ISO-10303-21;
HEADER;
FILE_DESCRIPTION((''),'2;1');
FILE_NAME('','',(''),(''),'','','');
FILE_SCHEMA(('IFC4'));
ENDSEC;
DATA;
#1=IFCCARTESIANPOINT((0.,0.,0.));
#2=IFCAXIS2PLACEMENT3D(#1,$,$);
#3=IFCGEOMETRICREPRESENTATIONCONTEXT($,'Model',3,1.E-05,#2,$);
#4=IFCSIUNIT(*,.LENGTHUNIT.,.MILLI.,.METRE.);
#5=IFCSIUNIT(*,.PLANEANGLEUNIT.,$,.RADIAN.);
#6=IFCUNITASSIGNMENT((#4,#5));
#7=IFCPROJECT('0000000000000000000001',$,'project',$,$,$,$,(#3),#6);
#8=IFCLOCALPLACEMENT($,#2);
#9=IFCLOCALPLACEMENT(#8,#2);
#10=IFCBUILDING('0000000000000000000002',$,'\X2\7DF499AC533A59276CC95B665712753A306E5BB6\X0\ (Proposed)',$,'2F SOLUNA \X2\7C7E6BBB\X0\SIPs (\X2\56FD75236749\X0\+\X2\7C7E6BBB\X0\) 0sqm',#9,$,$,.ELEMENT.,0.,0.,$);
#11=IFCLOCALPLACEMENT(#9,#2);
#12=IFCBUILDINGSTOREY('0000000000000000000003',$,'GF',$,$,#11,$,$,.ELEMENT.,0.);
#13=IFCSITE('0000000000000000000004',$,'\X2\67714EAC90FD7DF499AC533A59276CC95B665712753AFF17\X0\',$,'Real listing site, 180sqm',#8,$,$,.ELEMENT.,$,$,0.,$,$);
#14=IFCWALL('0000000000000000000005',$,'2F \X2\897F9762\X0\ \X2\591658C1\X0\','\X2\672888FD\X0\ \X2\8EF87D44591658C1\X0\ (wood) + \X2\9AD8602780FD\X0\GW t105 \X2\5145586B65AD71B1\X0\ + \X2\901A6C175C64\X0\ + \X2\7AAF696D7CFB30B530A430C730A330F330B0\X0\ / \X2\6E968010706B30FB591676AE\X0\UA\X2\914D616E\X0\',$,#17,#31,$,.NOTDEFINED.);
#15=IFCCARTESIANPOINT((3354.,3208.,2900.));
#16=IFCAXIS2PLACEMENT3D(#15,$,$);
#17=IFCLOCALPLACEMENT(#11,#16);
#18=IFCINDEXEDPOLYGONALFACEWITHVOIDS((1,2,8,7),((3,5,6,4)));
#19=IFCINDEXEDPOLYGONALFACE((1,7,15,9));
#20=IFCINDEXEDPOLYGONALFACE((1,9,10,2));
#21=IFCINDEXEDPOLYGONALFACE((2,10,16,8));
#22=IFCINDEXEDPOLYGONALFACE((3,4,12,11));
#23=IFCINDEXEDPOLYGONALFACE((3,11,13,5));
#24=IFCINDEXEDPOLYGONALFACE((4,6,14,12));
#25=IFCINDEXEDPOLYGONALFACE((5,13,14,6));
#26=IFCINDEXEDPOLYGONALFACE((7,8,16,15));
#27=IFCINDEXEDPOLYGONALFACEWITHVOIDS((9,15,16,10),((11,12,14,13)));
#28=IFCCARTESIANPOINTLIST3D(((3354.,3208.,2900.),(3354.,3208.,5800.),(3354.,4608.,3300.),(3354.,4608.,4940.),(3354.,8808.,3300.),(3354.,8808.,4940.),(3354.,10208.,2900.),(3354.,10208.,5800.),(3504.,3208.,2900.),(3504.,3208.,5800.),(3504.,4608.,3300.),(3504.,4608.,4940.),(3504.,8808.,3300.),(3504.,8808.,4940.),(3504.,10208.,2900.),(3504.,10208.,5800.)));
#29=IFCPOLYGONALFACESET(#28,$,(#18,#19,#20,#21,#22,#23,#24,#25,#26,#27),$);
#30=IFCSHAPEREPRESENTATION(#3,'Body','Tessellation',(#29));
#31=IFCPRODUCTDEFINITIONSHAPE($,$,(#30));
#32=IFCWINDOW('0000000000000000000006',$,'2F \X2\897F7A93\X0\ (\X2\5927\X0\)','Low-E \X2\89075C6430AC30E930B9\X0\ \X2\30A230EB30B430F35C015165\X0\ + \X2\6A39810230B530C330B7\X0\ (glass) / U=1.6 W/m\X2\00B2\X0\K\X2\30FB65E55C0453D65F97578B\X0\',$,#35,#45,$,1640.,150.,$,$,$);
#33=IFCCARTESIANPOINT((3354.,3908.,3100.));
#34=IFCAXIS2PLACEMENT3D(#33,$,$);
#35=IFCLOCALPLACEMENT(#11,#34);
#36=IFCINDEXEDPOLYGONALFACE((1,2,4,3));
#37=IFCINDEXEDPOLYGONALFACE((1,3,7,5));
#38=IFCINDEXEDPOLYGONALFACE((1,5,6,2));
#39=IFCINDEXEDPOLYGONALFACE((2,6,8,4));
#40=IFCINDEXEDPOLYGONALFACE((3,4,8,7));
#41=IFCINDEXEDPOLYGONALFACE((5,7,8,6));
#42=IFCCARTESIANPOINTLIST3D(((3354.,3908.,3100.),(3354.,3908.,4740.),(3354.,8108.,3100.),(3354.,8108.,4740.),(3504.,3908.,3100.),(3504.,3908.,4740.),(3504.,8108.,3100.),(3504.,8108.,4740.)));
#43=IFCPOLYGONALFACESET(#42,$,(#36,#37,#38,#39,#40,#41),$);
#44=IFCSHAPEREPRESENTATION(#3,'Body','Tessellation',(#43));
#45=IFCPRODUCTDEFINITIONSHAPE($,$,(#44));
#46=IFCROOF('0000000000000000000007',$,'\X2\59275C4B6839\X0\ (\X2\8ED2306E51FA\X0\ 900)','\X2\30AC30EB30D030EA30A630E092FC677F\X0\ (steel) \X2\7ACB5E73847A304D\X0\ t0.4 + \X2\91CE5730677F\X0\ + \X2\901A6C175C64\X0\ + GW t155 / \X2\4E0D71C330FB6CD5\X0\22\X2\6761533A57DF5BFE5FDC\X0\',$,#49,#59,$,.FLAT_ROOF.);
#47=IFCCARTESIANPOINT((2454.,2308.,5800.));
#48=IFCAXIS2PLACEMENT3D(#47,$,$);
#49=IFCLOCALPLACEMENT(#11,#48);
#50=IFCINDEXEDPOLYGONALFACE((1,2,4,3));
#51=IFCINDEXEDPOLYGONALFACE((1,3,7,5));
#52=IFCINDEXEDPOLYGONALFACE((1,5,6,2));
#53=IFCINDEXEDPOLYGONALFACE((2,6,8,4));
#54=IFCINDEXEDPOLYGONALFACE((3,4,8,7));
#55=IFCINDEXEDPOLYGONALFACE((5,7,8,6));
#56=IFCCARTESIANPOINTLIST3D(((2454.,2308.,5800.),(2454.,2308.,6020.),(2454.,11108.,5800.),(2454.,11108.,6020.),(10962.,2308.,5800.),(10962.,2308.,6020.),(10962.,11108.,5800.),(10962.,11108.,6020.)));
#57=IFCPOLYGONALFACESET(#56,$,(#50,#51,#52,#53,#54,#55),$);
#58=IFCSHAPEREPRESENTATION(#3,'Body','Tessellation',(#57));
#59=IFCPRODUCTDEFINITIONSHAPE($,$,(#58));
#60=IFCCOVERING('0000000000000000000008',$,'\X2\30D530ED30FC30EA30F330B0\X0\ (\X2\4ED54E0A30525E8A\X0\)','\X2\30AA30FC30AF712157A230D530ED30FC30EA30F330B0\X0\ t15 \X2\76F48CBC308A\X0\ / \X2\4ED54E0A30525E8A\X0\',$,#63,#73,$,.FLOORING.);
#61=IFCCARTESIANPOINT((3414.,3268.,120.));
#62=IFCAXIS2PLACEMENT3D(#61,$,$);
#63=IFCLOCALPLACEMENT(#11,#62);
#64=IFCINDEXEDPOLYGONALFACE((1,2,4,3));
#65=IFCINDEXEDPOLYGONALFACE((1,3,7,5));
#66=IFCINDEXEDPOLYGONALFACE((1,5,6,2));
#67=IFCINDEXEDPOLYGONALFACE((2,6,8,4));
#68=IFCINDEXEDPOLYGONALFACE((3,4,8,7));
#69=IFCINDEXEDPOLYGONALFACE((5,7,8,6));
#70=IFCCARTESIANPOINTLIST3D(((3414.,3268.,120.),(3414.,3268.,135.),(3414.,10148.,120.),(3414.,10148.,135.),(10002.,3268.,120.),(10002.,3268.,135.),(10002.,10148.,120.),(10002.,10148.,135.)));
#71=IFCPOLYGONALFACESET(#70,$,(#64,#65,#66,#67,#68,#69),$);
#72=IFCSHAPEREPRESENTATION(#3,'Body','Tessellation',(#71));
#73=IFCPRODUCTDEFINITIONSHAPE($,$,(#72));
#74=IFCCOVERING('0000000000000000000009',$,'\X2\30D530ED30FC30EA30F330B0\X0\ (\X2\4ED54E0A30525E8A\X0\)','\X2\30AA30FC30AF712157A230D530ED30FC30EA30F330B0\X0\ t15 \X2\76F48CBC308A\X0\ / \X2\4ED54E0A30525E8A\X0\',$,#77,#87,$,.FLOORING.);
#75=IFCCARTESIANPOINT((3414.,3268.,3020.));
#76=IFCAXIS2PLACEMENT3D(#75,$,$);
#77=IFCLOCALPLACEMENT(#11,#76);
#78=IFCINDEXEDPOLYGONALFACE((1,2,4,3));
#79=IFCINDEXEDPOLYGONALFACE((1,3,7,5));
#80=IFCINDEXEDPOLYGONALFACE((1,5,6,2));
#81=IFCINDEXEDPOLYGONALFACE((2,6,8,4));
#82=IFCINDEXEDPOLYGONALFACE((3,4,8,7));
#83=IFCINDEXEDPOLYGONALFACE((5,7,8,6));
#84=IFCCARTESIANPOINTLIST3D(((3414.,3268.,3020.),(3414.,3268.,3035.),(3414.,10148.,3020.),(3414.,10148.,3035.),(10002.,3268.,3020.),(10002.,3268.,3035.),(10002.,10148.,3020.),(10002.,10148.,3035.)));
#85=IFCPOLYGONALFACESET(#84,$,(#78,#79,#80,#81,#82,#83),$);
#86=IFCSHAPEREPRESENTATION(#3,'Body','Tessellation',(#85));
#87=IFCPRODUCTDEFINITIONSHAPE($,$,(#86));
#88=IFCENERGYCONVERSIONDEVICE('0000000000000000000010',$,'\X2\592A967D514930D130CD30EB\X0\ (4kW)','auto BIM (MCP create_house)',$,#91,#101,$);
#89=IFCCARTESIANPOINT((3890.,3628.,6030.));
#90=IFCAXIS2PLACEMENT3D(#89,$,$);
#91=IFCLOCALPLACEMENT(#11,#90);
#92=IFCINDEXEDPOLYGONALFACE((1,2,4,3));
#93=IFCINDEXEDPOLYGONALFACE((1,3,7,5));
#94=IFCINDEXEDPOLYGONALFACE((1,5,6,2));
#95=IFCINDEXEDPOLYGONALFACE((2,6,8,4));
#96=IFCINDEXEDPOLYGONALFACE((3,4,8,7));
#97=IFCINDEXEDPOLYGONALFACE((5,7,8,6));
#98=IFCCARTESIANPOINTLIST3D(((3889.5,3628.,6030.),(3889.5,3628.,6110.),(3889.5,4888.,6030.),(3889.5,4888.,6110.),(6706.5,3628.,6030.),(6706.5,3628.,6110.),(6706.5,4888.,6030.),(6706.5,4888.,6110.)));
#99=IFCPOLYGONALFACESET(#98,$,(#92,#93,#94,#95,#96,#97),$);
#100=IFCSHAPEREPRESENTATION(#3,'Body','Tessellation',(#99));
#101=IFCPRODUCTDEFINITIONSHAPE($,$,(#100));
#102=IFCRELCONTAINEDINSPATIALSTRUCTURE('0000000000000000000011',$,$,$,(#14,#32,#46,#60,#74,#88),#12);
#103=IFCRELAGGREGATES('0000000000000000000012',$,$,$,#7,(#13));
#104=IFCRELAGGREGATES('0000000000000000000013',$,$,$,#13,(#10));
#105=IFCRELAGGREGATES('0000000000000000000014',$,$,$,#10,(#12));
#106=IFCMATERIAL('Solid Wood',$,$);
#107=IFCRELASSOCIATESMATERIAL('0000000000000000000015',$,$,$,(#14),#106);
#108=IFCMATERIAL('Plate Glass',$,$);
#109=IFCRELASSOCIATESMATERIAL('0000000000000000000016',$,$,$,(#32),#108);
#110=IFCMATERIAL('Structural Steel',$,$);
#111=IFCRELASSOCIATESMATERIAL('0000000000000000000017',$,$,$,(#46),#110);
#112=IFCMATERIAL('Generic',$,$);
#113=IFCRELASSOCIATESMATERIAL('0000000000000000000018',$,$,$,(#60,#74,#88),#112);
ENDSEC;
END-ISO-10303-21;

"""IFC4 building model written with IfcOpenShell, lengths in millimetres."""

from ifc_helpers import new_model, si_unit, frame, frame_2d, origin, place, context, project, spatial, rectangle, extrude, material, element, fill, save


model = new_model("IFC4")

# Units and contexts
model_context = context("Model", 3, precision=1e-05, world=origin())
ifc_project = project(units=[si_unit("LENGTHUNIT", "METRE", prefix="MILLI"), si_unit("PLANEANGLEUNIT", "RADIAN")], contexts=[model_context])

# Site, building, storey
site_placement = place(None, origin())
site = spatial("IfcSite", under=ifc_project, at=site_placement, Name="東京都練馬区大泉学園町７", ObjectType="Real listing site, 180sqm", CompositionType="ELEMENT", RefElevation=0.0)
building_placement = place(site_placement, origin())
building = spatial("IfcBuilding", under=site, at=building_placement, Name="練馬区大泉学園町の家 (Proposed)", ObjectType="2F SOLUNA 籾殻SIPs (国産杉+籾殻) 0sqm", CompositionType="ELEMENT", ElevationOfRefHeight=0.0, ElevationOfTerrain=0.0)
storey_placement = place(building_placement, origin())
storey = spatial("IfcBuildingStorey", under=building, at=storey_placement, Name="GF", CompositionType="ELEMENT", Elevation=0.0)

# Shared definitions
ifc_material_1 = material(Name="Solid Wood")

# Shared definitions
ifc_material_2 = material(Name="Plate Glass")

# Wall, opening, window
wall_1_placement = place(storey_placement, frame((3354.0, 3208.0, 2900.0)))
wall_1 = element("IfcWall", 1, at=wall_1_placement, inside=storey, material=ifc_material_1, Name="2F 西面 外壁", Description="木製 軸組外壁 (wood) + 高性能GW t105 充填断熱 + 通気層 + 窯業系サイディング / 準耐火・外皮UA配慮", PredefinedType="NOTDEFINED", context=model_context, shape_type="SweptSolid", body=[
    extrude(rectangle(XDim=150.0, YDim=7000.0, at=frame_2d((75.0, 3500.0))), frame((3354.0, 3208.0, 2900.0)), (0.0, 0.0, 1.0), 2900.0),
])
opening_1_placement = place(storey_placement, frame((3354.0, 3908.0, 3100.0)))
opening_1 = element("IfcOpeningElement", 2, at=opening_1_placement, cuts=wall_1, PredefinedType="NOTDEFINED", context=model_context, shape_type="SweptSolid", body=[
    extrude(rectangle(XDim=150.0, YDim=4200.0, at=frame_2d((75.0, 2100.0))), frame((3354.0, 3908.0, 3100.0)), (0.0, 0.0, 1.0), 1640.0),
])
window_1_placement = place(storey_placement, frame((3354.0, 3908.0, 3100.0)))
window_1 = element("IfcWindow", 3, at=window_1_placement, inside=storey, material=ifc_material_2, Name="2F 西窓 (大)", Description="Low-E 複層ガラス アルゴン封入 + 樹脂サッシ (glass) / U=1.6 W/m²K・日射取得型", OverallHeight=1640.0, OverallWidth=150.0, context=model_context, shape_type="SweptSolid", body=[
    extrude(rectangle(XDim=150.0, YDim=4200.0, at=frame_2d((75.0, 2100.0))), frame((3354.0, 3908.0, 3100.0)), (0.0, 0.0, 1.0), 1640.0),
])
fill(opening_1, window_1)

# Roof
ifc_material_3 = material(Name="Structural Steel")
roof_placement = place(storey_placement, frame((2454.0, 2308.0, 5800.0)))
element("IfcRoof", 4, at=roof_placement, inside=storey, material=ifc_material_3, Name="大屋根 (軒の出 900)", Description="ガルバリウム鋼板 (steel) 立平葺き t0.4 + 野地板 + 通気層 + GW t155 / 不燃・法22条区域対応", PredefinedType="FLAT_ROOF", context=model_context, shape_type="SweptSolid", body=[
    extrude(rectangle(XDim=8508.0, YDim=8800.0, at=frame_2d((4254.0, 4400.0))), frame((2454.0, 2308.0, 5800.0)), (0.0, 0.0, 1.0), 220.0),
])

# Coverings
ifc_material_4 = material(Name="Generic")
covering_1_placement = place(storey_placement, frame((3414.0, 3268.0, 120.0)))
element("IfcCovering", 5, at=covering_1_placement, inside=storey, material=ifc_material_4, Name="フローリング (仕上げ床)", Description="オーク無垢フローリング t15 直貼り / 仕上げ床", PredefinedType="FLOORING", context=model_context, shape_type="SweptSolid", body=[
    extrude(rectangle(XDim=6588.0, YDim=6880.0, at=frame_2d((3294.0, 3440.0))), frame((3414.0, 3268.0, 120.0)), (0.0, 0.0, 1.0), 15.0),
])
covering_2_placement = place(storey_placement, frame((3414.0, 3268.0, 3020.0)))
element("IfcCovering", 6, at=covering_2_placement, inside=storey, material=ifc_material_4, Name="フローリング (仕上げ床)", Description="オーク無垢フローリング t15 直貼り / 仕上げ床", PredefinedType="FLOORING", context=model_context, shape_type="SweptSolid", body=[
    extrude(rectangle(XDim=6588.0, YDim=6880.0, at=frame_2d((3294.0, 3440.0))), frame((3414.0, 3268.0, 3020.0)), (0.0, 0.0, 1.0), 15.0),
])

# Energy conversion device
energy_conversion_device_placement = place(storey_placement, frame((3890.0, 3628.0, 6030.0)))
element("IfcEnergyConversionDevice", 7, at=energy_conversion_device_placement, inside=storey, material=ifc_material_4, Name="太陽光パネル (4kW)", Description="auto BIM (MCP create_house)", context=model_context, shape_type="SweptSolid", body=[
    extrude(rectangle(XDim=2817.0, YDim=1260.0, at=frame_2d((1408.0, 630.0))), frame((3890.0, 3628.0, 6030.0)), (0.0, 0.0, 1.0), 80.0),
])

save(model, "model.ifc")
